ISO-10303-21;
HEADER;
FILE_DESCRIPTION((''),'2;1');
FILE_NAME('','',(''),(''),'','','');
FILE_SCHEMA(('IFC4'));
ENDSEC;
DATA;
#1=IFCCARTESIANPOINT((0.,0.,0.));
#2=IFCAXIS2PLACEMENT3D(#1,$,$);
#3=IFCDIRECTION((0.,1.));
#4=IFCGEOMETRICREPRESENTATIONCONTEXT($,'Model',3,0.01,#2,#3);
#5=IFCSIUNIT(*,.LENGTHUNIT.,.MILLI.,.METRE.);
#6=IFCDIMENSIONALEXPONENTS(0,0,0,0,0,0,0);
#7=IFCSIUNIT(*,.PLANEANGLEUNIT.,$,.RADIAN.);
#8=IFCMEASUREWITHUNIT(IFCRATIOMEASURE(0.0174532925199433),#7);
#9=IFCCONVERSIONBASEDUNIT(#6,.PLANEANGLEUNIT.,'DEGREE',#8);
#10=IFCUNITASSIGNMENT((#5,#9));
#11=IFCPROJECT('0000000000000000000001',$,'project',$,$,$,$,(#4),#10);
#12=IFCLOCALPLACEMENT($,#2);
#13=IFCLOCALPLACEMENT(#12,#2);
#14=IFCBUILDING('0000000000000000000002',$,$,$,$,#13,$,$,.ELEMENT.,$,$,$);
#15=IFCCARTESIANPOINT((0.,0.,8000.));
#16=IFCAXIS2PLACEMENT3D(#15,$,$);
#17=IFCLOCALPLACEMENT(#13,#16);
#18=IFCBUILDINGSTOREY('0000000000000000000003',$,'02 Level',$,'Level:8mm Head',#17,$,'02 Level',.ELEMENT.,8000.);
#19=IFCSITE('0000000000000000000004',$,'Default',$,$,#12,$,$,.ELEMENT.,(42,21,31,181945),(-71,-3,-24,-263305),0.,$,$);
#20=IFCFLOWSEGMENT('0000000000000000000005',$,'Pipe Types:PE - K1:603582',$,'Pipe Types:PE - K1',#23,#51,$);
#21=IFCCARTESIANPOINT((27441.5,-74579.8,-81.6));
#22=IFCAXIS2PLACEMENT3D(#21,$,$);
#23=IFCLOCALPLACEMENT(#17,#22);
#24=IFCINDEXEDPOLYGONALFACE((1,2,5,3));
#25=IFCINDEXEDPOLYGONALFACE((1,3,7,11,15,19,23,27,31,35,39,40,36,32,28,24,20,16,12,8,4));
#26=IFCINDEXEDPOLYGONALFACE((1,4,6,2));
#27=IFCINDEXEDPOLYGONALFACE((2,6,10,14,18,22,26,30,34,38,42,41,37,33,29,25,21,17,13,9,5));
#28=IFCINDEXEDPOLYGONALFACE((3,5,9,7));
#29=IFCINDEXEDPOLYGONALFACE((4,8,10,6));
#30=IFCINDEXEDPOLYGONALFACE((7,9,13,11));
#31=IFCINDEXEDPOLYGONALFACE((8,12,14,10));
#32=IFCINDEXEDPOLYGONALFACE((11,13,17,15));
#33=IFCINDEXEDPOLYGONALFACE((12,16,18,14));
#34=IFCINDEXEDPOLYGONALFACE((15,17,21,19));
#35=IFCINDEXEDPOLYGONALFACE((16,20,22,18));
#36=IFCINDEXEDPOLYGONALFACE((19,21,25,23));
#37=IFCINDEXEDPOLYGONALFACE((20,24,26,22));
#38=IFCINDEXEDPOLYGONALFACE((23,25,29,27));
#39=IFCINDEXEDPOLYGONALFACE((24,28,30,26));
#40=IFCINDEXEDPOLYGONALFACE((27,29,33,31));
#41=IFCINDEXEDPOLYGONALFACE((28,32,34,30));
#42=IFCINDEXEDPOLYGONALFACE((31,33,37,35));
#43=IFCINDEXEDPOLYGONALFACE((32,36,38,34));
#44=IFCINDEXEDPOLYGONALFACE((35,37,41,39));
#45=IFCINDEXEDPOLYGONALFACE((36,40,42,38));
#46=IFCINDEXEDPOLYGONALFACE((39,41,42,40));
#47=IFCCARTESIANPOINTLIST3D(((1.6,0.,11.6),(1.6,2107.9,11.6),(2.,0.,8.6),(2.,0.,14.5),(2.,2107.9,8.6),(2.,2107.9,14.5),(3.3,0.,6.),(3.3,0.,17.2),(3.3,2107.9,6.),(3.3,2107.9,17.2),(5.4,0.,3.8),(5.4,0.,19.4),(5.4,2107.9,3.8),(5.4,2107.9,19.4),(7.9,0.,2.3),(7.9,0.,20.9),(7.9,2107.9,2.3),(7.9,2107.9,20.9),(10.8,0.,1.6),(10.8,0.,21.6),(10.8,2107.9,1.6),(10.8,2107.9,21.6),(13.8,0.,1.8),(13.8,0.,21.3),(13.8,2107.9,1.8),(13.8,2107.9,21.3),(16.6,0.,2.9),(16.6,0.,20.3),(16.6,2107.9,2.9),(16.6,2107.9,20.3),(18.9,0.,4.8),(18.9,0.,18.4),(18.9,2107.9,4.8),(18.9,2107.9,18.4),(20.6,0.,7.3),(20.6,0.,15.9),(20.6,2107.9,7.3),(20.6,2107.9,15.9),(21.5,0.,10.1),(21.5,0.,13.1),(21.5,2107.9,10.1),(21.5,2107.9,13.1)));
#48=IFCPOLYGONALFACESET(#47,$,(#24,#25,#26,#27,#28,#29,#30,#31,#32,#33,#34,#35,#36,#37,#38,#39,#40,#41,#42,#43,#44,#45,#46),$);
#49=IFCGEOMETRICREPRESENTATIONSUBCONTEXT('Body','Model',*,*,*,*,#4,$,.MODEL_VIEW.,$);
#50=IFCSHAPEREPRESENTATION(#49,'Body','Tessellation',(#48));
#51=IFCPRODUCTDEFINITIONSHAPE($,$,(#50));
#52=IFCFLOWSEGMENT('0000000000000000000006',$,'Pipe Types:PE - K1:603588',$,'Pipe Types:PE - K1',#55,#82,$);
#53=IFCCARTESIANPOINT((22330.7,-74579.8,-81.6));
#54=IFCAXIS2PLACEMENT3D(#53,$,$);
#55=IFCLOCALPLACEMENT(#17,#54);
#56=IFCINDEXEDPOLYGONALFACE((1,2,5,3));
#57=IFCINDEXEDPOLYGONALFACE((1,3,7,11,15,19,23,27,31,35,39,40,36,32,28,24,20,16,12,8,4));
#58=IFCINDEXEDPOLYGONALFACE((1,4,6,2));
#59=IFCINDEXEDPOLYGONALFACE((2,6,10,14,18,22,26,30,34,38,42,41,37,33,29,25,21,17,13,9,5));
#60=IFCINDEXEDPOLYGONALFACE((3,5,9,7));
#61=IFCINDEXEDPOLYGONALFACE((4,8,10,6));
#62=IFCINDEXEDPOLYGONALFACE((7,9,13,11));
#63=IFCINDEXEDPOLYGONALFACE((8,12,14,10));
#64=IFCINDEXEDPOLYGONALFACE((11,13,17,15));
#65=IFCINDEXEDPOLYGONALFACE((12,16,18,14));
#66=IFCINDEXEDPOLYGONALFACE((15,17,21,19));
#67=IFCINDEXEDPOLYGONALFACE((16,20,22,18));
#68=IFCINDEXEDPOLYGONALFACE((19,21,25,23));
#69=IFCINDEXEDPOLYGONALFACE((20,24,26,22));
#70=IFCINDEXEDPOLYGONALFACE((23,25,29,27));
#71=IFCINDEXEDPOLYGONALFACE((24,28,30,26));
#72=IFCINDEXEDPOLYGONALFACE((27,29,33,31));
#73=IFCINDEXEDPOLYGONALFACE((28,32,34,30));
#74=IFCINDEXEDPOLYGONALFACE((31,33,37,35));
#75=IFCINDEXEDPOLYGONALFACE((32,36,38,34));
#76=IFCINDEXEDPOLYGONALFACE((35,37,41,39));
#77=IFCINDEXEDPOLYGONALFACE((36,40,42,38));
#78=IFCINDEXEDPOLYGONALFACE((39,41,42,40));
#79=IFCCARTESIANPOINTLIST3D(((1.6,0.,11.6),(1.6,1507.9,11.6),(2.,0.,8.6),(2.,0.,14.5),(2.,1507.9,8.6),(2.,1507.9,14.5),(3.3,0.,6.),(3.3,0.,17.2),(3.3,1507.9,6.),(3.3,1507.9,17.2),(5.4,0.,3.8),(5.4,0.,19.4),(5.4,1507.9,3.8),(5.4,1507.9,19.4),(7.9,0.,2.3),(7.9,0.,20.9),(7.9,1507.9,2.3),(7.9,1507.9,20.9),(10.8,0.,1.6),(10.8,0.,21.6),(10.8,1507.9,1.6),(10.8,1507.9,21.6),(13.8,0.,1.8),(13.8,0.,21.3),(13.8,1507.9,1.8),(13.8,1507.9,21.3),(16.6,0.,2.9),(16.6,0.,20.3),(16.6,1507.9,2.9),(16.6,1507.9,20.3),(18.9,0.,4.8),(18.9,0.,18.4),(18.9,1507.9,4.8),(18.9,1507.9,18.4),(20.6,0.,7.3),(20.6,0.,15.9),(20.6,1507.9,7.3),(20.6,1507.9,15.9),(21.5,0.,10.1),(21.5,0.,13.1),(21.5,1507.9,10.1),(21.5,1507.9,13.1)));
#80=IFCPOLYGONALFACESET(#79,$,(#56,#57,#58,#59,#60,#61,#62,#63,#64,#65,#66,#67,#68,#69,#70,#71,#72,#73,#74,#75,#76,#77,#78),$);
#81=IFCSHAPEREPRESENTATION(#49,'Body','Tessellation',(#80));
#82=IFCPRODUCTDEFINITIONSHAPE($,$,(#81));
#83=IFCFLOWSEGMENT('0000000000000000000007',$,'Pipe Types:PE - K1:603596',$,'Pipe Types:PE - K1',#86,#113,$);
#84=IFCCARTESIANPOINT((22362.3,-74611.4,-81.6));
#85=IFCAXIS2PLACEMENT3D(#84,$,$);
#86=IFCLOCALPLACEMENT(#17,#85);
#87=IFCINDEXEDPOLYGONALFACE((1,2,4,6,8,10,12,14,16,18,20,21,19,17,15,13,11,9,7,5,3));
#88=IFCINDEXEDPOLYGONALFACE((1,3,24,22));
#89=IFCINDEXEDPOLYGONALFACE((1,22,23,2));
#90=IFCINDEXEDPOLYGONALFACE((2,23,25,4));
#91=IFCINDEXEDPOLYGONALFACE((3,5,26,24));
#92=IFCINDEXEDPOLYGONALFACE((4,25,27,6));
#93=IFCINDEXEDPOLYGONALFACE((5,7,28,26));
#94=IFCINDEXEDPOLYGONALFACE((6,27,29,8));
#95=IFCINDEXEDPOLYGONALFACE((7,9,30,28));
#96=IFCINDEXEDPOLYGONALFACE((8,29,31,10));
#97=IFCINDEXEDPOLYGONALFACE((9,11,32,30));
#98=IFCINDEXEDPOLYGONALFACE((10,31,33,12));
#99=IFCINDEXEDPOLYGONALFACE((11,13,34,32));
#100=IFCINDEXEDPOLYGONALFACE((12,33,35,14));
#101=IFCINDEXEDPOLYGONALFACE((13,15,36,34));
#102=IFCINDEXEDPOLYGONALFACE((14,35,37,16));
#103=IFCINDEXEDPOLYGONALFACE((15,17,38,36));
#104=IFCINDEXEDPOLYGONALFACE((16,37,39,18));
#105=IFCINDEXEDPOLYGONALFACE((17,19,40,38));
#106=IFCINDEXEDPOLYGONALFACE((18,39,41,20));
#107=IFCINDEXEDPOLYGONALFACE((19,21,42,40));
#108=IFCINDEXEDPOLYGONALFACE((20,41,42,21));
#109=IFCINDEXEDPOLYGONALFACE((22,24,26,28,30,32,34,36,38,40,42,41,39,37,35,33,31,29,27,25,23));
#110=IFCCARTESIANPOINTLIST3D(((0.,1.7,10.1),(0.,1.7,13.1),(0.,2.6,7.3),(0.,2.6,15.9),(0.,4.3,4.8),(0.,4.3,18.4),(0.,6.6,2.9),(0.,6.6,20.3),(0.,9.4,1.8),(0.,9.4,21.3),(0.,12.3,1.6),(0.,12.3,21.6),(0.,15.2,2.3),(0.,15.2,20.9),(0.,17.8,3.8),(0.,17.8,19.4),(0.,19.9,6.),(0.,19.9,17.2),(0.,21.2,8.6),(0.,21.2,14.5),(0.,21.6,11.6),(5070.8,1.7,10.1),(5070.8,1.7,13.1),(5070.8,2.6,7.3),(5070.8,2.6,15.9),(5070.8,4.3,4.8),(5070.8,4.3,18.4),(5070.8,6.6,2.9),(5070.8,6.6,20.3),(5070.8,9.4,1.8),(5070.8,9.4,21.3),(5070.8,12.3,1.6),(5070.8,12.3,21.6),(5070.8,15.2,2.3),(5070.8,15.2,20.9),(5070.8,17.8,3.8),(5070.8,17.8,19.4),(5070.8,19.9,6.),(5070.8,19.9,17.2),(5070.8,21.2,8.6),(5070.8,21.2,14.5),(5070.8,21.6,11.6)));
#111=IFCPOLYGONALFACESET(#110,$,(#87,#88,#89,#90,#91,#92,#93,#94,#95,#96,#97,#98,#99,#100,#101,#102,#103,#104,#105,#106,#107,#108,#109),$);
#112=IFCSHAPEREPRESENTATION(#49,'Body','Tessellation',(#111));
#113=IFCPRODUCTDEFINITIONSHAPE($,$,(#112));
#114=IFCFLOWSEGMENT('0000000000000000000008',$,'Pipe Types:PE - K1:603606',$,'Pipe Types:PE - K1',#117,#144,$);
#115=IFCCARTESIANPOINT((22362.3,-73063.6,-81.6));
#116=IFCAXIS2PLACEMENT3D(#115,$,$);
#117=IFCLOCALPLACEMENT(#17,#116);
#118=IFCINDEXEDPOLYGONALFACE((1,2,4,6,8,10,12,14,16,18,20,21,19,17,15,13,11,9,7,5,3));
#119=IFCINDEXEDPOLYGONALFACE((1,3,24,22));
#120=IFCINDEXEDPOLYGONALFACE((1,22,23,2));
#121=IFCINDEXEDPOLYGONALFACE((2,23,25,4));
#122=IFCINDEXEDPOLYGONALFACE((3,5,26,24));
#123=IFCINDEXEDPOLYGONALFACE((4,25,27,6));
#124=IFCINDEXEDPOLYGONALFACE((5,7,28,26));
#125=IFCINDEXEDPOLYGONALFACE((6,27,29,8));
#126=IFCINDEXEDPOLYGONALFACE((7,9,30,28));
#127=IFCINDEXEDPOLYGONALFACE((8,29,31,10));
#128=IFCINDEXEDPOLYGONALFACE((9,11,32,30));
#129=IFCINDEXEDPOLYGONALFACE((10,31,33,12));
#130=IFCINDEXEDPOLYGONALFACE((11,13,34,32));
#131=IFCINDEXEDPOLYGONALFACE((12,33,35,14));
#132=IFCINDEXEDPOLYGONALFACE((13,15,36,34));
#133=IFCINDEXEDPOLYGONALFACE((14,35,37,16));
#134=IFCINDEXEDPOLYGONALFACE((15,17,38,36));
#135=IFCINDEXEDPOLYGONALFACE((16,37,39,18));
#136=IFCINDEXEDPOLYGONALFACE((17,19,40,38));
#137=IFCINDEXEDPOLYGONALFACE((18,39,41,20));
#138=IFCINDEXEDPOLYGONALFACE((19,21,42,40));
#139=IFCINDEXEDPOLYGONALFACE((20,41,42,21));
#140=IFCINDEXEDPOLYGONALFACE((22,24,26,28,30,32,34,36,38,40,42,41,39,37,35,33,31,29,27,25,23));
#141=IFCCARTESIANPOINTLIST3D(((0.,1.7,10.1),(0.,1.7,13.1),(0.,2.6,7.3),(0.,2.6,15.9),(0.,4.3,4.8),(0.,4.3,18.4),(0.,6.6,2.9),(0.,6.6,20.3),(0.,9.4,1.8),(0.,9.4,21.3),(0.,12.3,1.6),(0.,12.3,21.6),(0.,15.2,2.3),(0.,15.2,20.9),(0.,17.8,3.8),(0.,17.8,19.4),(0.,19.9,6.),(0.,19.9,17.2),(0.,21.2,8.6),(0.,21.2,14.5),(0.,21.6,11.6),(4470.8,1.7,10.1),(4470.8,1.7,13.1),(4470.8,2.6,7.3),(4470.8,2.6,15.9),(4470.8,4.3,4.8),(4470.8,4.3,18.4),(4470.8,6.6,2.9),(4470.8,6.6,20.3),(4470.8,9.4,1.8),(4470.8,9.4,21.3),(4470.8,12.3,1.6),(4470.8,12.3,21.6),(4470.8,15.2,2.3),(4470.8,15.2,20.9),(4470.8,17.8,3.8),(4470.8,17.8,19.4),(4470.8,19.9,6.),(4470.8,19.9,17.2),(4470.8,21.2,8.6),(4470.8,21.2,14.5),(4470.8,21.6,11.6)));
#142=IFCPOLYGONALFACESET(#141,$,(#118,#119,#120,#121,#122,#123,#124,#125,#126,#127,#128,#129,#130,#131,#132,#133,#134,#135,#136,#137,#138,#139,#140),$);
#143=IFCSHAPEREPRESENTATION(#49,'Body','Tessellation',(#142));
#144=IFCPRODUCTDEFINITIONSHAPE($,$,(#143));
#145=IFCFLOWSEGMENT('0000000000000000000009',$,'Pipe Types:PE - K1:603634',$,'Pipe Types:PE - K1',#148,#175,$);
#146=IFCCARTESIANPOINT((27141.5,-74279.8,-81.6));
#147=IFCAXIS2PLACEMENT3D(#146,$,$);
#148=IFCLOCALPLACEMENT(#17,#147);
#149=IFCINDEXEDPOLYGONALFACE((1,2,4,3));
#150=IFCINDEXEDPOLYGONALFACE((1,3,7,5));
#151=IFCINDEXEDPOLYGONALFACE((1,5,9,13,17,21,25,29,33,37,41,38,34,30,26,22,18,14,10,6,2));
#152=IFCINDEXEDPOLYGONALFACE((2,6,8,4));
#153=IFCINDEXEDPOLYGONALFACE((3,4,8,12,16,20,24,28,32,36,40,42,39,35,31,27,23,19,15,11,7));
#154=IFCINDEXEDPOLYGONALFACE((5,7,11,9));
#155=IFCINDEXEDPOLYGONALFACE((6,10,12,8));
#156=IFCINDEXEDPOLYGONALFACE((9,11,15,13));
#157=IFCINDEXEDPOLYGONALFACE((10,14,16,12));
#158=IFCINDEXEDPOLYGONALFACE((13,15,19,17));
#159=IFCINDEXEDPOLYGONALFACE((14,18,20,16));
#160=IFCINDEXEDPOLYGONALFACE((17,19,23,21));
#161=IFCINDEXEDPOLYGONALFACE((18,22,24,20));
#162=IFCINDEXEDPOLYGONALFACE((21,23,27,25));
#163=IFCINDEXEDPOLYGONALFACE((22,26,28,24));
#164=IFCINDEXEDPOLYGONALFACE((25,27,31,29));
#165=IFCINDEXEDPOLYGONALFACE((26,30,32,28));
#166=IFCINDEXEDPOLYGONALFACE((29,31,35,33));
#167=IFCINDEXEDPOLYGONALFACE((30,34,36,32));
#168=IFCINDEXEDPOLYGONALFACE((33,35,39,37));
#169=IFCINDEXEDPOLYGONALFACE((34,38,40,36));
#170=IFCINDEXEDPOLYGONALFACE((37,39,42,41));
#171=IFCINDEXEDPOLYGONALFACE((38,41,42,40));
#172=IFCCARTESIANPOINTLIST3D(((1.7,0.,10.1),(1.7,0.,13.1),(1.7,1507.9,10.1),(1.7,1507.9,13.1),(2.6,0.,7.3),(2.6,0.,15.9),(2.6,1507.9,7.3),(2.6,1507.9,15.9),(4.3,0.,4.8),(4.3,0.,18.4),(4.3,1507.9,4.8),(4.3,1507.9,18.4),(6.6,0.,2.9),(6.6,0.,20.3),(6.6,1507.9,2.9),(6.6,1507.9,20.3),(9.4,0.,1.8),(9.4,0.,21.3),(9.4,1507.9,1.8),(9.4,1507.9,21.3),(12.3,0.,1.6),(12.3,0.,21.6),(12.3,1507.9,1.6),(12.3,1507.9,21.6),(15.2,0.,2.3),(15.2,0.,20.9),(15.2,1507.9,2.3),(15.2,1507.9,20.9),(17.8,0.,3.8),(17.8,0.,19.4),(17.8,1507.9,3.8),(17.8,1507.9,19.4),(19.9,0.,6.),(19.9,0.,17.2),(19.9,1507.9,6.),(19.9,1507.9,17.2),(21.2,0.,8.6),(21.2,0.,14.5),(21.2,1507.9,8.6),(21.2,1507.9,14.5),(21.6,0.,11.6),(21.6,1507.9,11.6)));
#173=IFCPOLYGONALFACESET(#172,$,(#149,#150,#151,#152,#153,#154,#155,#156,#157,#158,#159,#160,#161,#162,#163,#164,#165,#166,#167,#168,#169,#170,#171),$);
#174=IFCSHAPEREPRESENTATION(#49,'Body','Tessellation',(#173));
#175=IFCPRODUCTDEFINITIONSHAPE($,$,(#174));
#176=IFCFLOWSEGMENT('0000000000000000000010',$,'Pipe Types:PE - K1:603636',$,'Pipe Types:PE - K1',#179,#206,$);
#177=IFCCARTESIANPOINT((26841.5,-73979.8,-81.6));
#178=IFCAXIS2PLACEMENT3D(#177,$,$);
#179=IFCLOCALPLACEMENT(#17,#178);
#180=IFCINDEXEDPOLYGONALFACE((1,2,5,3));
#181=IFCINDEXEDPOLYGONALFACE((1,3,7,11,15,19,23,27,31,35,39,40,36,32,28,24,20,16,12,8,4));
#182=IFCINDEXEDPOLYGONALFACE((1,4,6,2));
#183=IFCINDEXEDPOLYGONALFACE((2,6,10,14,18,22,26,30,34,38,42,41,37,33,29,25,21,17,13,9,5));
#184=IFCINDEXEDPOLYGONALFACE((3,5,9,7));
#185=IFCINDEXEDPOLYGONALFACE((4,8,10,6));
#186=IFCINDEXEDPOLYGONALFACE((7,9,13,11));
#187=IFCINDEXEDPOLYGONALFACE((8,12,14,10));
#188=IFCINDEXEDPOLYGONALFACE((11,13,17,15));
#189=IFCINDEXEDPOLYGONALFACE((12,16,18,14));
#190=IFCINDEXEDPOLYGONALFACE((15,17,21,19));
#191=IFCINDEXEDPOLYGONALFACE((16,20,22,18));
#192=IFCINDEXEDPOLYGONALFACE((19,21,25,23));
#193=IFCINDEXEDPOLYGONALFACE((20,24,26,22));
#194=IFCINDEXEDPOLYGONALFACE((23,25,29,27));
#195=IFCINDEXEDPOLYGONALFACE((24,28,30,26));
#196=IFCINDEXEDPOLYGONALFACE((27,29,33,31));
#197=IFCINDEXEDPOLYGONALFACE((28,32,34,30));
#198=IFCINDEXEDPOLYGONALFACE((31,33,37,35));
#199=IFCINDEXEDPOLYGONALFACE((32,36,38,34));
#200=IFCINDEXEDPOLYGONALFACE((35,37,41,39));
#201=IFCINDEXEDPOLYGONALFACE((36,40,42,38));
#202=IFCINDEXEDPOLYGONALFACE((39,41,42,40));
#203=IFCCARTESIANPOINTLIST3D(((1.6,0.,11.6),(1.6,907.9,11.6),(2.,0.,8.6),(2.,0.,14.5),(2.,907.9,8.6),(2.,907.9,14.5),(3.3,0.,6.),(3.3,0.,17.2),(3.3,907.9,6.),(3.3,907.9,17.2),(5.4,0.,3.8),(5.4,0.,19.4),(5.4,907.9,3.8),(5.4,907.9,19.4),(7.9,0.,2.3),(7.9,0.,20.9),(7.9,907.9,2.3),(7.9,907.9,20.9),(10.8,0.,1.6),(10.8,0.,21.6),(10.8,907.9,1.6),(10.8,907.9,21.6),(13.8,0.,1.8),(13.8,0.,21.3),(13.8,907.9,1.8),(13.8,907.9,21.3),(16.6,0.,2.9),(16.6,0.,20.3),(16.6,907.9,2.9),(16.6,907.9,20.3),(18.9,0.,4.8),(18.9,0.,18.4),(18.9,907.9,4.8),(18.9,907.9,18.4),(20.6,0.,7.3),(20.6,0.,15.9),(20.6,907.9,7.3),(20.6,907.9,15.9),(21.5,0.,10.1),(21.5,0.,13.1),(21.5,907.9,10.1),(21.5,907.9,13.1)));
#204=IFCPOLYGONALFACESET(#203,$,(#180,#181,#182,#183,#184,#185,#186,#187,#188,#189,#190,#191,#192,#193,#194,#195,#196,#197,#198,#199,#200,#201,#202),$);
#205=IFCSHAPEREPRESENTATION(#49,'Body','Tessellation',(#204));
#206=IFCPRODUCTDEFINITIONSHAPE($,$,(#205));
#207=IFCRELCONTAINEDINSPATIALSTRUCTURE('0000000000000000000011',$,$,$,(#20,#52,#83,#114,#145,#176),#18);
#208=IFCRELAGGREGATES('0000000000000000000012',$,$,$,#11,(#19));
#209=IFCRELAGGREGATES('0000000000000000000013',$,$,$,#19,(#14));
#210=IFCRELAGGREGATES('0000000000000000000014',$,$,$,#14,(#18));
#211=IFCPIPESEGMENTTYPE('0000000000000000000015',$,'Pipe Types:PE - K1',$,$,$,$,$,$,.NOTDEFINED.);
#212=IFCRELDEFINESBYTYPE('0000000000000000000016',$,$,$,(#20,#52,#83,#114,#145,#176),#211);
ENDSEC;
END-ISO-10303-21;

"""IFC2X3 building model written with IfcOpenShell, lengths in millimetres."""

from ifc_helpers import new_model, entity, si_unit, converted_unit, direction, frame, frame_2d, origin, origin_2d_with_axis, place, context, subcontext, project, spatial, circle, extrude, type_object, element, save


model = new_model("IFC2X3")

# Units and contexts
model_context = context("Model", 3, precision=0.01, world=origin(), true_north=direction((0.0, 1.0)))
body_context = subcontext(model_context, "Body", "Model", "MODEL_VIEW")
ifc_project = project(units=[si_unit("LENGTHUNIT", "METRE", prefix="MILLI"), converted_unit("PLANEANGLEUNIT", "DEGREE", entity("IfcRatioMeasure", 0.0174532925199433), si_unit("PLANEANGLEUNIT", "RADIAN"), dimensions=[0, 0, 0, 0, 0, 0, 0])], contexts=[model_context])

# Site, building, storey
site_placement = place(None, origin())
site = spatial("IfcSite", under=ifc_project, at=site_placement, Name="Default", CompositionType="ELEMENT", RefLatitude=(42, 21, 31, 181945), RefLongitude=(-71, -3, -24, -263305), RefElevation=0.0)
building_placement = place(site_placement, origin())
building = spatial("IfcBuilding", under=site, at=building_placement, CompositionType="ELEMENT")
storey_placement = place(building_placement, frame((0.0, 0.0, 8000.0)))
storey = spatial("IfcBuildingStorey", under=building, at=storey_placement, Name="02 Level", ObjectType="Level:8mm Head", LongName="02 Level", CompositionType="ELEMENT", Elevation=8000.0)

# Flow segments
pipe_segment_type = type_object("IfcPipeSegmentType", Name="Pipe Types:PE - K1", PredefinedType="NOTDEFINED")
flow_segment_1_placement = place(storey_placement, frame((27441.5, -74579.8, -81.6)))
element("IfcFlowSegment", 1, at=flow_segment_1_placement, inside=storey, type_object=pipe_segment_type, Name="Pipe Types:PE - K1:603582", ObjectType="Pipe Types:PE - K1", context=body_context, shape_type="SweptSolid", body=[
    extrude(circle(Radius=10.0, at=frame_2d((0.0, 0.0), x_axis=(1.0, 0.0))), frame((11.6, 0.0, 11.6), z_axis=(0.0, 1.0, 0.0), x_axis=(-1.0, 0.0, 0.0)), (0.0, 0.0, 1.0), 2107.9),
])
flow_segment_2_placement = place(storey_placement, frame((22330.7, -74579.8, -81.6)))
element("IfcFlowSegment", 2, at=flow_segment_2_placement, inside=storey, type_object=pipe_segment_type, Name="Pipe Types:PE - K1:603588", ObjectType="Pipe Types:PE - K1", context=body_context, shape_type="SweptSolid", body=[
    extrude(circle(Radius=10.0, at=frame_2d((0.0, 0.0), x_axis=(1.0, 0.0))), frame((11.6, 0.0, 11.6), z_axis=(0.0, 1.0, 0.0), x_axis=(-1.0, 0.0, 0.0)), (0.0, 0.0, 1.0), 1507.9),
])
flow_segment_3_placement = place(storey_placement, frame((22362.3, -74611.4, -81.6)))
element("IfcFlowSegment", 3, at=flow_segment_3_placement, inside=storey, type_object=pipe_segment_type, Name="Pipe Types:PE - K1:603596", ObjectType="Pipe Types:PE - K1", context=body_context, shape_type="SweptSolid", body=[
    extrude(circle(Radius=10.0, at=frame_2d((0.0, 0.0), x_axis=(1.0, 0.0))), frame((0.0, 11.6, 11.6), z_axis=(1.0, 0.0, 0.0), x_axis=(0.0, 1.0, 0.0)), (0.0, 0.0, 1.0), 5070.8),
])
flow_segment_4_placement = place(storey_placement, frame((22362.3, -73063.6, -81.6)))
element("IfcFlowSegment", 4, at=flow_segment_4_placement, inside=storey, type_object=pipe_segment_type, Name="Pipe Types:PE - K1:603606", ObjectType="Pipe Types:PE - K1", context=body_context, shape_type="SweptSolid", body=[
    extrude(circle(Radius=10.0, at=frame_2d((0.0, 0.0), x_axis=(1.0, 0.0))), frame((0.0, 11.6, 11.6), z_axis=(1.0, 0.0, 0.0), x_axis=(0.0, 1.0, 0.0)), (0.0, 0.0, 1.0), 4470.8),
])
flow_segment_5_placement = place(storey_placement, frame((27141.5, -74279.8, -81.6)))
element("IfcFlowSegment", 5, at=flow_segment_5_placement, inside=storey, type_object=pipe_segment_type, Name="Pipe Types:PE - K1:603634", ObjectType="Pipe Types:PE - K1", context=body_context, shape_type="SweptSolid", body=[
    extrude(circle(Radius=10.0, at=origin_2d_with_axis()), frame((11.6, 0.0, 11.6), z_axis=(0.0, 1.0, 0.0), x_axis=(1.0, 0.0, 0.0)), (0.0, 0.0, 1.0), 1507.9),
])
flow_segment_6_placement = place(storey_placement, frame((26841.5, -73979.8, -81.6)))
element("IfcFlowSegment", 6, at=flow_segment_6_placement, inside=storey, type_object=pipe_segment_type, Name="Pipe Types:PE - K1:603636", ObjectType="Pipe Types:PE - K1", context=body_context, shape_type="SweptSolid", body=[
    extrude(circle(Radius=10.0, at=frame_2d((0.0, 0.0), x_axis=(1.0, 0.0))), frame((11.6, 0.0, 11.6), z_axis=(0.0, 1.0, 0.0), x_axis=(-1.0, 0.0, 0.0)), (0.0, 0.0, 1.0), 907.9),
])

save(model, "model.ifc")
